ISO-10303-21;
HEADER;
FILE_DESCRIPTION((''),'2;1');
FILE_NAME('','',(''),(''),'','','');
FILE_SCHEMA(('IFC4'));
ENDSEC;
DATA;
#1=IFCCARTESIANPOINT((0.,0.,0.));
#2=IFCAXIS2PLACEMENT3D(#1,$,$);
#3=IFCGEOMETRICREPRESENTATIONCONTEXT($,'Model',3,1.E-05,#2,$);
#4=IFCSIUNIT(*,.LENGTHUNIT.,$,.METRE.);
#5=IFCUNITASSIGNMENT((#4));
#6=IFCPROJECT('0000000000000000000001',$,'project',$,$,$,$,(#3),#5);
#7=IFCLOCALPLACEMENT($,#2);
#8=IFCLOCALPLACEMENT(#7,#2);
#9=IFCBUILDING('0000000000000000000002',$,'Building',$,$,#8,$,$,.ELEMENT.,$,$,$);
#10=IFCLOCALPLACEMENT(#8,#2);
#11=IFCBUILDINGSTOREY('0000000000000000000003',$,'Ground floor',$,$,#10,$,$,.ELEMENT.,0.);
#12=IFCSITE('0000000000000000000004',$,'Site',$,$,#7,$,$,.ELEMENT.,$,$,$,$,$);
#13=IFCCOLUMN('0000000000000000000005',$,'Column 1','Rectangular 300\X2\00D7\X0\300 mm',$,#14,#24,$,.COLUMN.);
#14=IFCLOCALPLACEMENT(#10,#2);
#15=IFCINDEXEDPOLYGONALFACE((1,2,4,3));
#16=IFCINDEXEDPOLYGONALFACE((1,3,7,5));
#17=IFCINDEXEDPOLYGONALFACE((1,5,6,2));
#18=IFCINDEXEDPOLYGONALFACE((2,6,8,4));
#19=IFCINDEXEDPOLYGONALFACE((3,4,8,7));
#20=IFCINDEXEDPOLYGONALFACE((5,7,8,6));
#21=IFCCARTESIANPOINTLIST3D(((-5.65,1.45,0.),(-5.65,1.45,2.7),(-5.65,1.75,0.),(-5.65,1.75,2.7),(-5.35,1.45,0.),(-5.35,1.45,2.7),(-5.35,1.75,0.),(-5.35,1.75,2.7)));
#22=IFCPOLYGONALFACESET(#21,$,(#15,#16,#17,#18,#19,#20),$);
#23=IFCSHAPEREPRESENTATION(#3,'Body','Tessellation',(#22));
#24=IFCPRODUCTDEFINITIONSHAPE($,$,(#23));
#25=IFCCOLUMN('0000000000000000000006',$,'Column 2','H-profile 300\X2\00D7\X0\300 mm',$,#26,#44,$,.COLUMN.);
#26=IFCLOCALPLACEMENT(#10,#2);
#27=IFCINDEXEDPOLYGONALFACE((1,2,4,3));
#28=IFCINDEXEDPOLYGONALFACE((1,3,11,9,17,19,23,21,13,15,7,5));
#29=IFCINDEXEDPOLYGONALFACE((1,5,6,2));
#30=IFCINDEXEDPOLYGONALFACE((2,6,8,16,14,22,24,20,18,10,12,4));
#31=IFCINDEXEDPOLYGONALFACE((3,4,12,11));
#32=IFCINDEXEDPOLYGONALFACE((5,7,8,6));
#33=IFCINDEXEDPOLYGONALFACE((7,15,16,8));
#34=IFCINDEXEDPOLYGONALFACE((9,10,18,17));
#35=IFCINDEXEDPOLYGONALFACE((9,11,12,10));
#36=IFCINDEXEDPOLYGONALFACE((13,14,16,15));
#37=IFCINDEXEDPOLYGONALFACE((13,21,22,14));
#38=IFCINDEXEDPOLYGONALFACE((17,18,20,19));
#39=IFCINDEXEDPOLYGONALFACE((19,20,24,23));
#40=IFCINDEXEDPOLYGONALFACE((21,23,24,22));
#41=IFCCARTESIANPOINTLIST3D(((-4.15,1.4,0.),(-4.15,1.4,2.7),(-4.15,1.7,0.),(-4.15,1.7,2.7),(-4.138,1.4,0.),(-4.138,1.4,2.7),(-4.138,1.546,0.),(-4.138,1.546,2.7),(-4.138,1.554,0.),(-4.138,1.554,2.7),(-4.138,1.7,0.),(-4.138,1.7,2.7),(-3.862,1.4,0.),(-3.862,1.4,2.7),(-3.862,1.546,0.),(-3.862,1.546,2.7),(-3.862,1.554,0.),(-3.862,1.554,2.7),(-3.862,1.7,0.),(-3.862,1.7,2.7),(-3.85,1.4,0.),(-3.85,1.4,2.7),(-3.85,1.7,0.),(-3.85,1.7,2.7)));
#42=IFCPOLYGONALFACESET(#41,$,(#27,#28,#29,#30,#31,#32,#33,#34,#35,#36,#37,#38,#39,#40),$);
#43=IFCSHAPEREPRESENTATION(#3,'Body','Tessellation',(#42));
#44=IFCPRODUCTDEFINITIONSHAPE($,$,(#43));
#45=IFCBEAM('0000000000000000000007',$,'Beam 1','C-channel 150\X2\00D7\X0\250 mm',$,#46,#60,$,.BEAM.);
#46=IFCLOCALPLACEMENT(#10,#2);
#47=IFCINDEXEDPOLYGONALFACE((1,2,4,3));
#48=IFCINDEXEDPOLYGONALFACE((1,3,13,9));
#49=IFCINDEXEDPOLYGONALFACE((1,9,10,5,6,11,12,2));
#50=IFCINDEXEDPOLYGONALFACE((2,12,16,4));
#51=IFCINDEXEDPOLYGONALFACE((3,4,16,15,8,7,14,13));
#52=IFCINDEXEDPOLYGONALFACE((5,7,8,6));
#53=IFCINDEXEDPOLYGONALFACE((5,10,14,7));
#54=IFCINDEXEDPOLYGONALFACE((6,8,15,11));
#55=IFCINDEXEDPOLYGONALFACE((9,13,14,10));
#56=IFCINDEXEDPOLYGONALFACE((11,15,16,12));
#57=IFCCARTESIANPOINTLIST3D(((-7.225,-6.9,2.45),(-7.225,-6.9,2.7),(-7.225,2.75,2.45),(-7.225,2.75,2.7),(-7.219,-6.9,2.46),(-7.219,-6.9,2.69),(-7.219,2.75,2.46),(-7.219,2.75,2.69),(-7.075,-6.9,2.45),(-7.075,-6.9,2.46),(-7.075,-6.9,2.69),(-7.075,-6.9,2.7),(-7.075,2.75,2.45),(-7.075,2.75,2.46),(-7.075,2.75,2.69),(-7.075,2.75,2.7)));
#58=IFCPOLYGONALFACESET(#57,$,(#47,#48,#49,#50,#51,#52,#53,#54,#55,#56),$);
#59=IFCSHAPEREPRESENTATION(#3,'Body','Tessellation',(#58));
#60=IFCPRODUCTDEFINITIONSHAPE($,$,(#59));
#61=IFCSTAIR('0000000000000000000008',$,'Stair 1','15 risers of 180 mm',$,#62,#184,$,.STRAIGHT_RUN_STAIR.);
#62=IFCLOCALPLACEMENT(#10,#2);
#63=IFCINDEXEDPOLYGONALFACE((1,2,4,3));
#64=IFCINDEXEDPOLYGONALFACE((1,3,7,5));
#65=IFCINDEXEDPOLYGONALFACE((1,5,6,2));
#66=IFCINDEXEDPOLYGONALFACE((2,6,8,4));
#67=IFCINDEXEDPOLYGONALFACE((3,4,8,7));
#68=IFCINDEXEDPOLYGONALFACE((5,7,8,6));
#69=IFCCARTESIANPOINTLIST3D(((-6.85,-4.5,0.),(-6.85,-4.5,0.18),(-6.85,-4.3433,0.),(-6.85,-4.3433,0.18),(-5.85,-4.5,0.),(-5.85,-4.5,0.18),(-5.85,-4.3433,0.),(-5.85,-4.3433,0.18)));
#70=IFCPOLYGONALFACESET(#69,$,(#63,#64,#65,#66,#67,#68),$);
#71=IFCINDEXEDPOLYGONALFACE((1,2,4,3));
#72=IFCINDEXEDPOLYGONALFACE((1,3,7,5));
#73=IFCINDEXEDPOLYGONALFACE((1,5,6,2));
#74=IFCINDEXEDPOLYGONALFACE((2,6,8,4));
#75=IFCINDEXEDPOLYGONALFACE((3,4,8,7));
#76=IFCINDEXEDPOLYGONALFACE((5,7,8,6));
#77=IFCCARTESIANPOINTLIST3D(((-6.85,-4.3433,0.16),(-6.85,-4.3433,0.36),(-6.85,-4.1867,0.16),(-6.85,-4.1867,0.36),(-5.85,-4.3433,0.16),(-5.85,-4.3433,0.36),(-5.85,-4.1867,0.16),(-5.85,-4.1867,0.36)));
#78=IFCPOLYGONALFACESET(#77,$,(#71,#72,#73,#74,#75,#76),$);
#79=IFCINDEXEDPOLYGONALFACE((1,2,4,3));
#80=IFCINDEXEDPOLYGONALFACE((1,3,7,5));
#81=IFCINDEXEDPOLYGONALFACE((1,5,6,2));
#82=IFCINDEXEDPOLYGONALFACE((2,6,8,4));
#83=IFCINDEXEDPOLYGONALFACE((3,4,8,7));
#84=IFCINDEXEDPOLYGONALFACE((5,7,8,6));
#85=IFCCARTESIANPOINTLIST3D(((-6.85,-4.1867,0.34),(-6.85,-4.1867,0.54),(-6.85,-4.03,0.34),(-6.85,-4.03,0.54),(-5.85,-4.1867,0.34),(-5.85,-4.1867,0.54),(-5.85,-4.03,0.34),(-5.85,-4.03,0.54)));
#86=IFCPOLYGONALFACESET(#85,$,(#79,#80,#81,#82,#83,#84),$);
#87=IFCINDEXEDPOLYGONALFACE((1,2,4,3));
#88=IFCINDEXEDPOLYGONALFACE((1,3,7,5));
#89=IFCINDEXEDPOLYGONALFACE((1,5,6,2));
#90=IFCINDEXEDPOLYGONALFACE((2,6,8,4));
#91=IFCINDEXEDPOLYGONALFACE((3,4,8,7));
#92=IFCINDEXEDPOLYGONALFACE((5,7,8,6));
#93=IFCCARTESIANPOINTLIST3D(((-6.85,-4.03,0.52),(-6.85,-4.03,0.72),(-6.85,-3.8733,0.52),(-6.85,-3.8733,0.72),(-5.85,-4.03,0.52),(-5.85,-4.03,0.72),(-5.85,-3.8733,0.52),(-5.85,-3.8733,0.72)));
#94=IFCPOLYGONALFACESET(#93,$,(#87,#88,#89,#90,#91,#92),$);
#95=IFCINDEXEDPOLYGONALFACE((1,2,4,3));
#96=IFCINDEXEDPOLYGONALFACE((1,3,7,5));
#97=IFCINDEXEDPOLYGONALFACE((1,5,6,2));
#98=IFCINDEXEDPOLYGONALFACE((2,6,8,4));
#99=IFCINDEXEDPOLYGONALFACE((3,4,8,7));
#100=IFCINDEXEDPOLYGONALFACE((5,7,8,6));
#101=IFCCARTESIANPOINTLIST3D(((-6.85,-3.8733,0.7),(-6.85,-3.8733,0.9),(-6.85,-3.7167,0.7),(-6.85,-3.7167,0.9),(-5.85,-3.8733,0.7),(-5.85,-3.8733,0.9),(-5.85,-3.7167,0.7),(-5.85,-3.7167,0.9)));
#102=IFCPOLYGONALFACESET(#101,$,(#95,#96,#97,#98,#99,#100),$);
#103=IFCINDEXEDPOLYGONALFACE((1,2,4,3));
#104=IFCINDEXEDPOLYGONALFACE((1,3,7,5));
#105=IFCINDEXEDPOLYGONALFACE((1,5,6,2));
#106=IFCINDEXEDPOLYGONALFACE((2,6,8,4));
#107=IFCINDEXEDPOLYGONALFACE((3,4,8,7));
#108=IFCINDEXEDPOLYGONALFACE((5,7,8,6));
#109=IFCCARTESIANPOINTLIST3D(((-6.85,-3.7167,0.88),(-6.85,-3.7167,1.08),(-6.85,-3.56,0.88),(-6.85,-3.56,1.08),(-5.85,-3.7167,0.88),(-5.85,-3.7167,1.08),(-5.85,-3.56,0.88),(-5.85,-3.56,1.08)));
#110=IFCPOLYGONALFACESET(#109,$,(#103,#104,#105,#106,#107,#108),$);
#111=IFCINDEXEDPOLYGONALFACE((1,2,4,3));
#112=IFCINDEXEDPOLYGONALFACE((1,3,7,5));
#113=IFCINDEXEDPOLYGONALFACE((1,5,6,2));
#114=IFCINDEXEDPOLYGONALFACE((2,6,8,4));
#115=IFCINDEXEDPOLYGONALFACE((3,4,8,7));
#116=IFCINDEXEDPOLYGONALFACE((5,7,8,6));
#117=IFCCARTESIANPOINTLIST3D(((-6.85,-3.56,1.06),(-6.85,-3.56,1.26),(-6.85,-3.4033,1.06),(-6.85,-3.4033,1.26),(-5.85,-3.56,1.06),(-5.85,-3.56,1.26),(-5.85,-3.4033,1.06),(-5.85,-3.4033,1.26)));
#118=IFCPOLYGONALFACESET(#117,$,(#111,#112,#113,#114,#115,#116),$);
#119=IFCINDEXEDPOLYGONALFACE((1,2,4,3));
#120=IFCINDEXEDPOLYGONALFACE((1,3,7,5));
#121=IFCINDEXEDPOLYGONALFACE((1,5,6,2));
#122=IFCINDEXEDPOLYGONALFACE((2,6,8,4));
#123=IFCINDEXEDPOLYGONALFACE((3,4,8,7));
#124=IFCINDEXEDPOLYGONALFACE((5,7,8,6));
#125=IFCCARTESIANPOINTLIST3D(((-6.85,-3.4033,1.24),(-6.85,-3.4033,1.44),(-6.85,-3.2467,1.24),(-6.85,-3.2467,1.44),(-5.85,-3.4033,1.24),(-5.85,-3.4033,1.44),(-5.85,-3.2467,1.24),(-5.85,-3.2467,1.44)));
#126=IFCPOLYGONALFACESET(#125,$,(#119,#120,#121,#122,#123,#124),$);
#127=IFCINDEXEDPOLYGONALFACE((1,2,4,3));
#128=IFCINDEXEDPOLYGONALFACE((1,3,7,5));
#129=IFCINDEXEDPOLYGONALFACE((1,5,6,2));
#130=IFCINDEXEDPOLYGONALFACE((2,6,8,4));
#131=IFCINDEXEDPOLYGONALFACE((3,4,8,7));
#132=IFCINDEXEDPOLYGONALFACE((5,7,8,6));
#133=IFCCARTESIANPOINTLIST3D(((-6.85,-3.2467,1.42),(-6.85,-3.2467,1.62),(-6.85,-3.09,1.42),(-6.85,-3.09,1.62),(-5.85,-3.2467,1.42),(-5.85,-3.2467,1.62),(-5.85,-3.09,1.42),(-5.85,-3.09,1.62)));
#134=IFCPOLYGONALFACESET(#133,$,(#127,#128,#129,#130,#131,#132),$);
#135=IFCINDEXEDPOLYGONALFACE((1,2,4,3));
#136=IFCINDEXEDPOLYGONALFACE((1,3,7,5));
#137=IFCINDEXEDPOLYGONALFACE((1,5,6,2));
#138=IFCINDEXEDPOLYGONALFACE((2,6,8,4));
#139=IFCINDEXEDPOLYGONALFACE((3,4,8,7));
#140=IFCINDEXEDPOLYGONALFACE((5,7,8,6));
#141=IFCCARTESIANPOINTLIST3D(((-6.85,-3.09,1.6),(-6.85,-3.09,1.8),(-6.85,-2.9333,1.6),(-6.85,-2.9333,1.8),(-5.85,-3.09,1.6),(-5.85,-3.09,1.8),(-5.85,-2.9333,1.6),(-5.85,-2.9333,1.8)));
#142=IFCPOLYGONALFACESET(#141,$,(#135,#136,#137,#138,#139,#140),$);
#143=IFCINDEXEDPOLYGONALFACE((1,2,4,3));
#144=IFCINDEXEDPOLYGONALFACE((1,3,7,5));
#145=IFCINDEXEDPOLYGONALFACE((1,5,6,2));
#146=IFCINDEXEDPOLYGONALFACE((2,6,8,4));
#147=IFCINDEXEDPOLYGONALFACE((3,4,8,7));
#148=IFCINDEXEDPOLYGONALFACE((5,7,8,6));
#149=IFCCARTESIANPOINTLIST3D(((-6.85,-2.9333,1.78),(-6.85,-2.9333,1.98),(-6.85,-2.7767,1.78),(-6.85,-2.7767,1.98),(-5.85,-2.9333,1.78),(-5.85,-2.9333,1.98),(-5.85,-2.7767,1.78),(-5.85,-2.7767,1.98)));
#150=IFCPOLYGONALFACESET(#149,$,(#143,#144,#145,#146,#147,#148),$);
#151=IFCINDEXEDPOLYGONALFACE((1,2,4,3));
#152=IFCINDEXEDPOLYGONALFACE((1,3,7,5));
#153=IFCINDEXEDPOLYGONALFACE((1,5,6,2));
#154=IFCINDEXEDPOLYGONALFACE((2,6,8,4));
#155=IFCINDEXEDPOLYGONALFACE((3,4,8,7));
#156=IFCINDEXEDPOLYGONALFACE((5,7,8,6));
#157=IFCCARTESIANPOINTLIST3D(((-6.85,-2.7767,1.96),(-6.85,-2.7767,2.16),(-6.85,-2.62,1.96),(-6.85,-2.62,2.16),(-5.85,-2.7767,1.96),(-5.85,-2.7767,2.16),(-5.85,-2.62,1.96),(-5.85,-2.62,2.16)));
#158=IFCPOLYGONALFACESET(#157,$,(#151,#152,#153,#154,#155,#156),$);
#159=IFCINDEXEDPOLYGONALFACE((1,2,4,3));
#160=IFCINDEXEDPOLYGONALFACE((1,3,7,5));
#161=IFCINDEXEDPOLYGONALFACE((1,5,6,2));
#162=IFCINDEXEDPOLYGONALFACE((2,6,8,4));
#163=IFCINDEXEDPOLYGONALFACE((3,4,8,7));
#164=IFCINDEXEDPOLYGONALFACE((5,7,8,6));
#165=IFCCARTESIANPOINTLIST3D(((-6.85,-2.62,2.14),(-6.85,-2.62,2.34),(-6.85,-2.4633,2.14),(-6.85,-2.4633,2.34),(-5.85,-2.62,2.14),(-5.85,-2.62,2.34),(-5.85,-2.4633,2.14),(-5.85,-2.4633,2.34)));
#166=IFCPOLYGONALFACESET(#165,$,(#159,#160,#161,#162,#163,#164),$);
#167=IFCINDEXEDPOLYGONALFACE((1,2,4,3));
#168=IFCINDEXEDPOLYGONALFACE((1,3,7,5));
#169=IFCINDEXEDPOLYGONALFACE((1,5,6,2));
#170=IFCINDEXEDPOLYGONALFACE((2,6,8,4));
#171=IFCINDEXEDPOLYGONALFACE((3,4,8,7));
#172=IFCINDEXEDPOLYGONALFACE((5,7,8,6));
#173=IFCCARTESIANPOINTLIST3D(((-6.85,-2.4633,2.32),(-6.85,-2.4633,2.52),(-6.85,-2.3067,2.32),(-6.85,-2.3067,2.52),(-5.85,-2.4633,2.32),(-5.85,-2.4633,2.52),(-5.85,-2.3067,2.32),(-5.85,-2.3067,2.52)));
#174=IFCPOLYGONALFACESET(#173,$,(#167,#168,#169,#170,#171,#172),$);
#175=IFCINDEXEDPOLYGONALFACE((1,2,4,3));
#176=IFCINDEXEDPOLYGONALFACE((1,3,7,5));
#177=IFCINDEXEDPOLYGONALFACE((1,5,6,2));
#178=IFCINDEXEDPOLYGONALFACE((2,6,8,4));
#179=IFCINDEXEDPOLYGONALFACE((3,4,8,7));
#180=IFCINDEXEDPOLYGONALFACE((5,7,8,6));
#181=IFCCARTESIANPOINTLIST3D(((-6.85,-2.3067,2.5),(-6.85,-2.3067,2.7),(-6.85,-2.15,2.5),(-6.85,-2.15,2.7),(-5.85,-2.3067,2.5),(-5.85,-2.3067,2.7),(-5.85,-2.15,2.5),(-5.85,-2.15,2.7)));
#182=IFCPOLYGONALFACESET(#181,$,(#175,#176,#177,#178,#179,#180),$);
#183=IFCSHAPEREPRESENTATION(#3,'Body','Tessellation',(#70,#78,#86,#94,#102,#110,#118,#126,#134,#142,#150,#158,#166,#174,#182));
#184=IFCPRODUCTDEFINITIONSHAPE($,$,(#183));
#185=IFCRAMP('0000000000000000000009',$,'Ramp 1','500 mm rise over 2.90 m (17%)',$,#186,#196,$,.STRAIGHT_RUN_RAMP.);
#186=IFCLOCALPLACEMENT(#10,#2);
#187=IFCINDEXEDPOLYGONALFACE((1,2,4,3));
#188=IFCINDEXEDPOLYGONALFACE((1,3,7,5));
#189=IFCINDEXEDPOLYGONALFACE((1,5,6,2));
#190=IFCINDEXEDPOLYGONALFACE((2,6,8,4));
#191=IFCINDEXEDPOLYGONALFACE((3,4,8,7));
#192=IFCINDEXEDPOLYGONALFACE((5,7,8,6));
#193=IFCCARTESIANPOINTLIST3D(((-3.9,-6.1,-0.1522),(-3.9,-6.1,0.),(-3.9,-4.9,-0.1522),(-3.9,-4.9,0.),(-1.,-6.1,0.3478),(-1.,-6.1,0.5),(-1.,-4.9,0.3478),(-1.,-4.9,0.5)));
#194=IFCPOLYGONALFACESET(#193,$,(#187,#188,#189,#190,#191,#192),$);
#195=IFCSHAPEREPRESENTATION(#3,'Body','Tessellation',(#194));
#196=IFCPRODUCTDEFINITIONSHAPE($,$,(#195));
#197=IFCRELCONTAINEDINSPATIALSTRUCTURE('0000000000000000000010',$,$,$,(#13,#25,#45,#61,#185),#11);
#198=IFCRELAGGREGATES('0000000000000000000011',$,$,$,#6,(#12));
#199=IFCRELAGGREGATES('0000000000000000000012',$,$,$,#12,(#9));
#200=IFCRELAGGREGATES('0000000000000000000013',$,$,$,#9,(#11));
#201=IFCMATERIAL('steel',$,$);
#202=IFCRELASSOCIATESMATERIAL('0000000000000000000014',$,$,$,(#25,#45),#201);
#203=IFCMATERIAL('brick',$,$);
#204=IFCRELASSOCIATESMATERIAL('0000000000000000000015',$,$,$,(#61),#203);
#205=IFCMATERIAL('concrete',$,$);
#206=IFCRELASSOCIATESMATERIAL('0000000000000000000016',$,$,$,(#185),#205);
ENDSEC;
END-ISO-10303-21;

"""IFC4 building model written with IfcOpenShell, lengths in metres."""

from ifc_helpers import new_model, si_unit, frame, origin, place, context, project, spatial, polyline, outline, extrude, material, element, save


model = new_model("IFC4")

# Units and contexts
model_context = context("Model", 3, precision=1e-05, world=origin())
ifc_project = project(units=[si_unit("LENGTHUNIT", "METRE")], contexts=[model_context])

# Site, building, storey
site_placement = place(None, origin())
site = spatial("IfcSite", under=ifc_project, at=site_placement, Name="Site", CompositionType="ELEMENT")
building_placement = place(site_placement, origin())
building = spatial("IfcBuilding", under=site, at=building_placement, Name="Building", CompositionType="ELEMENT")
storey_placement = place(building_placement, origin())
storey = spatial("IfcBuildingStorey", under=building, at=storey_placement, Name="Ground floor", CompositionType="ELEMENT", Elevation=0.0)

# Columns
column_1_placement = place(storey_placement, frame((-5.5, 1.6, 0.0), z_axis=(0.0, 0.0, 1.0), x_axis=(1.0, 0.0, 0.0)))
element("IfcColumn", 1, at=column_1_placement, inside=storey, Name="Column 1", Description="Rectangular 300×300 mm", PredefinedType="COLUMN", context=model_context, shape_type="SweptSolid", body=[
    extrude(outline(polyline([(-0.15, -0.15), (0.15, -0.15), (0.15, 0.15), (-0.15, 0.15), (-0.15, -0.15)])), origin(), (0.0, 0.0, 1.0), 2.7),
])
ifc_material_1 = material(Name="steel")
column_2_placement = place(storey_placement, frame((-4.0, 1.55, 0.0), z_axis=(0.0, 0.0, 1.0), x_axis=(1.0, 0.0, 0.0)))
element("IfcColumn", 2, at=column_2_placement, inside=storey, material=ifc_material_1, Name="Column 2", Description="H-profile 300×300 mm", PredefinedType="COLUMN", context=model_context, shape_type="SweptSolid", body=[
    extrude(outline(polyline([(-0.15, -0.15), (-0.138, -0.15), (-0.138, -0.004), (0.138, -0.004), (0.138, -0.15), (0.15, -0.15), (0.15, 0.15), (0.138, 0.15), (0.138, 0.004), (-0.138, 0.004), (-0.138, 0.15), (-0.15, 0.15), (-0.15, -0.15)])), origin(), (0.0, 0.0, 1.0), 2.7),
])

# Beam
beam_placement = place(storey_placement, frame((-7.15, 2.75, 2.575), z_axis=(0.0, -1.0, 0.0), x_axis=(1.0, 0.0, 0.0)))
element("IfcBeam", 3, at=beam_placement, inside=storey, material=ifc_material_1, Name="Beam 1", Description="C-channel 150×250 mm", PredefinedType="BEAM", context=model_context, shape_type="SweptSolid", body=[
    extrude(outline(polyline([(-0.075, -0.125), (0.075, -0.125), (0.075, -0.115), (-0.069, -0.115), (-0.069, 0.115), (0.075, 0.115), (0.075, 0.125), (-0.075, 0.125), (-0.075, -0.125)])), origin(), (0.0, 0.0, 1.0), 9.65),
])

# Stair
ifc_material_2 = material(Name="brick")
stair_placement = place(storey_placement, frame((-6.35, -4.5, 0.0), z_axis=(0.0, 0.0, 1.0), x_axis=(0.0, 1.0, 0.0)))
element("IfcStair", 4, at=stair_placement, inside=storey, material=ifc_material_2, Name="Stair 1", Description="15 risers of 180 mm", PredefinedType="STRAIGHT_RUN_STAIR", context=model_context, shape_type="SweptSolid", body=[
    extrude(outline(polyline([(0.0, -0.5), (0.1567, -0.5), (0.1567, 0.5), (0.0, 0.5), (0.0, -0.5)])), origin(), (0.0, 0.0, 1.0), 0.18),
    extrude(outline(polyline([(0.1567, -0.5), (0.3133, -0.5), (0.3133, 0.5), (0.1567, 0.5), (0.1567, -0.5)])), frame((0.0, 0.0, 0.16)), (0.0, 0.0, 1.0), 0.2),
    extrude(outline(polyline([(0.3133, -0.5), (0.47, -0.5), (0.47, 0.5), (0.3133, 0.5), (0.3133, -0.5)])), frame((0.0, 0.0, 0.34)), (0.0, 0.0, 1.0), 0.2),
    extrude(outline(polyline([(0.47, -0.5), (0.6267, -0.5), (0.6267, 0.5), (0.47, 0.5), (0.47, -0.5)])), frame((0.0, 0.0, 0.52)), (0.0, 0.0, 1.0), 0.2),
    extrude(outline(polyline([(0.6267, -0.5), (0.7833, -0.5), (0.7833, 0.5), (0.6267, 0.5), (0.6267, -0.5)])), frame((0.0, 0.0, 0.7)), (0.0, 0.0, 1.0), 0.2),
    extrude(outline(polyline([(0.7833, -0.5), (0.94, -0.5), (0.94, 0.5), (0.7833, 0.5), (0.7833, -0.5)])), frame((0.0, 0.0, 0.88)), (0.0, 0.0, 1.0), 0.2),
    extrude(outline(polyline([(0.94, -0.5), (1.0967, -0.5), (1.0967, 0.5), (0.94, 0.5), (0.94, -0.5)])), frame((0.0, 0.0, 1.06)), (0.0, 0.0, 1.0), 0.2),
    extrude(outline(polyline([(1.0967, -0.5), (1.2533, -0.5), (1.2533, 0.5), (1.0967, 0.5), (1.0967, -0.5)])), frame((0.0, 0.0, 1.24)), (0.0, 0.0, 1.0), 0.2),
    extrude(outline(polyline([(1.2533, -0.5), (1.41, -0.5), (1.41, 0.5), (1.2533, 0.5), (1.2533, -0.5)])), frame((0.0, 0.0, 1.42)), (0.0, 0.0, 1.0), 0.2),
    extrude(outline(polyline([(1.41, -0.5), (1.5667, -0.5), (1.5667, 0.5), (1.41, 0.5), (1.41, -0.5)])), frame((0.0, 0.0, 1.6)), (0.0, 0.0, 1.0), 0.2),
    extrude(outline(polyline([(1.5667, -0.5), (1.7233, -0.5), (1.7233, 0.5), (1.5667, 0.5), (1.5667, -0.5)])), frame((0.0, 0.0, 1.78)), (0.0, 0.0, 1.0), 0.2),
    extrude(outline(polyline([(1.7233, -0.5), (1.88, -0.5), (1.88, 0.5), (1.7233, 0.5), (1.7233, -0.5)])), frame((0.0, 0.0, 1.96)), (0.0, 0.0, 1.0), 0.2),
    extrude(outline(polyline([(1.88, -0.5), (2.0367, -0.5), (2.0367, 0.5), (1.88, 0.5), (1.88, -0.5)])), frame((0.0, 0.0, 2.14)), (0.0, 0.0, 1.0), 0.2),
    extrude(outline(polyline([(2.0367, -0.5), (2.1933, -0.5), (2.1933, 0.5), (2.0367, 0.5), (2.0367, -0.5)])), frame((0.0, 0.0, 2.32)), (0.0, 0.0, 1.0), 0.2),
    extrude(outline(polyline([(2.1933, -0.5), (2.35, -0.5), (2.35, 0.5), (2.1933, 0.5), (2.1933, -0.5)])), frame((0.0, 0.0, 2.5)), (0.0, 0.0, 1.0), 0.2),
])

# Ramp
ifc_material_3 = material(Name="concrete")
ramp_placement = place(storey_placement, frame((-3.9, -5.5, 0.0), z_axis=(0.0, 0.0, 1.0), x_axis=(1.0, 0.0, 0.0)))
element("IfcRamp", 5, at=ramp_placement, inside=storey, material=ifc_material_3, Name="Ramp 1", Description="500 mm rise over 2.90 m (17%)", PredefinedType="STRAIGHT_RUN_RAMP", context=model_context, shape_type="SweptSolid", body=[
    extrude(outline(polyline([(0.0, -0.1522), (2.9, 0.3478), (2.9, 0.5), (0.0, 0.0), (0.0, -0.1522)])), frame((0.0, 0.6, 0.0), z_axis=(0.0, -1.0, 0.0), x_axis=(1.0, 0.0, 0.0)), (0.0, 0.0, 1.0), 1.2),
])

save(model, "model.ifc")
